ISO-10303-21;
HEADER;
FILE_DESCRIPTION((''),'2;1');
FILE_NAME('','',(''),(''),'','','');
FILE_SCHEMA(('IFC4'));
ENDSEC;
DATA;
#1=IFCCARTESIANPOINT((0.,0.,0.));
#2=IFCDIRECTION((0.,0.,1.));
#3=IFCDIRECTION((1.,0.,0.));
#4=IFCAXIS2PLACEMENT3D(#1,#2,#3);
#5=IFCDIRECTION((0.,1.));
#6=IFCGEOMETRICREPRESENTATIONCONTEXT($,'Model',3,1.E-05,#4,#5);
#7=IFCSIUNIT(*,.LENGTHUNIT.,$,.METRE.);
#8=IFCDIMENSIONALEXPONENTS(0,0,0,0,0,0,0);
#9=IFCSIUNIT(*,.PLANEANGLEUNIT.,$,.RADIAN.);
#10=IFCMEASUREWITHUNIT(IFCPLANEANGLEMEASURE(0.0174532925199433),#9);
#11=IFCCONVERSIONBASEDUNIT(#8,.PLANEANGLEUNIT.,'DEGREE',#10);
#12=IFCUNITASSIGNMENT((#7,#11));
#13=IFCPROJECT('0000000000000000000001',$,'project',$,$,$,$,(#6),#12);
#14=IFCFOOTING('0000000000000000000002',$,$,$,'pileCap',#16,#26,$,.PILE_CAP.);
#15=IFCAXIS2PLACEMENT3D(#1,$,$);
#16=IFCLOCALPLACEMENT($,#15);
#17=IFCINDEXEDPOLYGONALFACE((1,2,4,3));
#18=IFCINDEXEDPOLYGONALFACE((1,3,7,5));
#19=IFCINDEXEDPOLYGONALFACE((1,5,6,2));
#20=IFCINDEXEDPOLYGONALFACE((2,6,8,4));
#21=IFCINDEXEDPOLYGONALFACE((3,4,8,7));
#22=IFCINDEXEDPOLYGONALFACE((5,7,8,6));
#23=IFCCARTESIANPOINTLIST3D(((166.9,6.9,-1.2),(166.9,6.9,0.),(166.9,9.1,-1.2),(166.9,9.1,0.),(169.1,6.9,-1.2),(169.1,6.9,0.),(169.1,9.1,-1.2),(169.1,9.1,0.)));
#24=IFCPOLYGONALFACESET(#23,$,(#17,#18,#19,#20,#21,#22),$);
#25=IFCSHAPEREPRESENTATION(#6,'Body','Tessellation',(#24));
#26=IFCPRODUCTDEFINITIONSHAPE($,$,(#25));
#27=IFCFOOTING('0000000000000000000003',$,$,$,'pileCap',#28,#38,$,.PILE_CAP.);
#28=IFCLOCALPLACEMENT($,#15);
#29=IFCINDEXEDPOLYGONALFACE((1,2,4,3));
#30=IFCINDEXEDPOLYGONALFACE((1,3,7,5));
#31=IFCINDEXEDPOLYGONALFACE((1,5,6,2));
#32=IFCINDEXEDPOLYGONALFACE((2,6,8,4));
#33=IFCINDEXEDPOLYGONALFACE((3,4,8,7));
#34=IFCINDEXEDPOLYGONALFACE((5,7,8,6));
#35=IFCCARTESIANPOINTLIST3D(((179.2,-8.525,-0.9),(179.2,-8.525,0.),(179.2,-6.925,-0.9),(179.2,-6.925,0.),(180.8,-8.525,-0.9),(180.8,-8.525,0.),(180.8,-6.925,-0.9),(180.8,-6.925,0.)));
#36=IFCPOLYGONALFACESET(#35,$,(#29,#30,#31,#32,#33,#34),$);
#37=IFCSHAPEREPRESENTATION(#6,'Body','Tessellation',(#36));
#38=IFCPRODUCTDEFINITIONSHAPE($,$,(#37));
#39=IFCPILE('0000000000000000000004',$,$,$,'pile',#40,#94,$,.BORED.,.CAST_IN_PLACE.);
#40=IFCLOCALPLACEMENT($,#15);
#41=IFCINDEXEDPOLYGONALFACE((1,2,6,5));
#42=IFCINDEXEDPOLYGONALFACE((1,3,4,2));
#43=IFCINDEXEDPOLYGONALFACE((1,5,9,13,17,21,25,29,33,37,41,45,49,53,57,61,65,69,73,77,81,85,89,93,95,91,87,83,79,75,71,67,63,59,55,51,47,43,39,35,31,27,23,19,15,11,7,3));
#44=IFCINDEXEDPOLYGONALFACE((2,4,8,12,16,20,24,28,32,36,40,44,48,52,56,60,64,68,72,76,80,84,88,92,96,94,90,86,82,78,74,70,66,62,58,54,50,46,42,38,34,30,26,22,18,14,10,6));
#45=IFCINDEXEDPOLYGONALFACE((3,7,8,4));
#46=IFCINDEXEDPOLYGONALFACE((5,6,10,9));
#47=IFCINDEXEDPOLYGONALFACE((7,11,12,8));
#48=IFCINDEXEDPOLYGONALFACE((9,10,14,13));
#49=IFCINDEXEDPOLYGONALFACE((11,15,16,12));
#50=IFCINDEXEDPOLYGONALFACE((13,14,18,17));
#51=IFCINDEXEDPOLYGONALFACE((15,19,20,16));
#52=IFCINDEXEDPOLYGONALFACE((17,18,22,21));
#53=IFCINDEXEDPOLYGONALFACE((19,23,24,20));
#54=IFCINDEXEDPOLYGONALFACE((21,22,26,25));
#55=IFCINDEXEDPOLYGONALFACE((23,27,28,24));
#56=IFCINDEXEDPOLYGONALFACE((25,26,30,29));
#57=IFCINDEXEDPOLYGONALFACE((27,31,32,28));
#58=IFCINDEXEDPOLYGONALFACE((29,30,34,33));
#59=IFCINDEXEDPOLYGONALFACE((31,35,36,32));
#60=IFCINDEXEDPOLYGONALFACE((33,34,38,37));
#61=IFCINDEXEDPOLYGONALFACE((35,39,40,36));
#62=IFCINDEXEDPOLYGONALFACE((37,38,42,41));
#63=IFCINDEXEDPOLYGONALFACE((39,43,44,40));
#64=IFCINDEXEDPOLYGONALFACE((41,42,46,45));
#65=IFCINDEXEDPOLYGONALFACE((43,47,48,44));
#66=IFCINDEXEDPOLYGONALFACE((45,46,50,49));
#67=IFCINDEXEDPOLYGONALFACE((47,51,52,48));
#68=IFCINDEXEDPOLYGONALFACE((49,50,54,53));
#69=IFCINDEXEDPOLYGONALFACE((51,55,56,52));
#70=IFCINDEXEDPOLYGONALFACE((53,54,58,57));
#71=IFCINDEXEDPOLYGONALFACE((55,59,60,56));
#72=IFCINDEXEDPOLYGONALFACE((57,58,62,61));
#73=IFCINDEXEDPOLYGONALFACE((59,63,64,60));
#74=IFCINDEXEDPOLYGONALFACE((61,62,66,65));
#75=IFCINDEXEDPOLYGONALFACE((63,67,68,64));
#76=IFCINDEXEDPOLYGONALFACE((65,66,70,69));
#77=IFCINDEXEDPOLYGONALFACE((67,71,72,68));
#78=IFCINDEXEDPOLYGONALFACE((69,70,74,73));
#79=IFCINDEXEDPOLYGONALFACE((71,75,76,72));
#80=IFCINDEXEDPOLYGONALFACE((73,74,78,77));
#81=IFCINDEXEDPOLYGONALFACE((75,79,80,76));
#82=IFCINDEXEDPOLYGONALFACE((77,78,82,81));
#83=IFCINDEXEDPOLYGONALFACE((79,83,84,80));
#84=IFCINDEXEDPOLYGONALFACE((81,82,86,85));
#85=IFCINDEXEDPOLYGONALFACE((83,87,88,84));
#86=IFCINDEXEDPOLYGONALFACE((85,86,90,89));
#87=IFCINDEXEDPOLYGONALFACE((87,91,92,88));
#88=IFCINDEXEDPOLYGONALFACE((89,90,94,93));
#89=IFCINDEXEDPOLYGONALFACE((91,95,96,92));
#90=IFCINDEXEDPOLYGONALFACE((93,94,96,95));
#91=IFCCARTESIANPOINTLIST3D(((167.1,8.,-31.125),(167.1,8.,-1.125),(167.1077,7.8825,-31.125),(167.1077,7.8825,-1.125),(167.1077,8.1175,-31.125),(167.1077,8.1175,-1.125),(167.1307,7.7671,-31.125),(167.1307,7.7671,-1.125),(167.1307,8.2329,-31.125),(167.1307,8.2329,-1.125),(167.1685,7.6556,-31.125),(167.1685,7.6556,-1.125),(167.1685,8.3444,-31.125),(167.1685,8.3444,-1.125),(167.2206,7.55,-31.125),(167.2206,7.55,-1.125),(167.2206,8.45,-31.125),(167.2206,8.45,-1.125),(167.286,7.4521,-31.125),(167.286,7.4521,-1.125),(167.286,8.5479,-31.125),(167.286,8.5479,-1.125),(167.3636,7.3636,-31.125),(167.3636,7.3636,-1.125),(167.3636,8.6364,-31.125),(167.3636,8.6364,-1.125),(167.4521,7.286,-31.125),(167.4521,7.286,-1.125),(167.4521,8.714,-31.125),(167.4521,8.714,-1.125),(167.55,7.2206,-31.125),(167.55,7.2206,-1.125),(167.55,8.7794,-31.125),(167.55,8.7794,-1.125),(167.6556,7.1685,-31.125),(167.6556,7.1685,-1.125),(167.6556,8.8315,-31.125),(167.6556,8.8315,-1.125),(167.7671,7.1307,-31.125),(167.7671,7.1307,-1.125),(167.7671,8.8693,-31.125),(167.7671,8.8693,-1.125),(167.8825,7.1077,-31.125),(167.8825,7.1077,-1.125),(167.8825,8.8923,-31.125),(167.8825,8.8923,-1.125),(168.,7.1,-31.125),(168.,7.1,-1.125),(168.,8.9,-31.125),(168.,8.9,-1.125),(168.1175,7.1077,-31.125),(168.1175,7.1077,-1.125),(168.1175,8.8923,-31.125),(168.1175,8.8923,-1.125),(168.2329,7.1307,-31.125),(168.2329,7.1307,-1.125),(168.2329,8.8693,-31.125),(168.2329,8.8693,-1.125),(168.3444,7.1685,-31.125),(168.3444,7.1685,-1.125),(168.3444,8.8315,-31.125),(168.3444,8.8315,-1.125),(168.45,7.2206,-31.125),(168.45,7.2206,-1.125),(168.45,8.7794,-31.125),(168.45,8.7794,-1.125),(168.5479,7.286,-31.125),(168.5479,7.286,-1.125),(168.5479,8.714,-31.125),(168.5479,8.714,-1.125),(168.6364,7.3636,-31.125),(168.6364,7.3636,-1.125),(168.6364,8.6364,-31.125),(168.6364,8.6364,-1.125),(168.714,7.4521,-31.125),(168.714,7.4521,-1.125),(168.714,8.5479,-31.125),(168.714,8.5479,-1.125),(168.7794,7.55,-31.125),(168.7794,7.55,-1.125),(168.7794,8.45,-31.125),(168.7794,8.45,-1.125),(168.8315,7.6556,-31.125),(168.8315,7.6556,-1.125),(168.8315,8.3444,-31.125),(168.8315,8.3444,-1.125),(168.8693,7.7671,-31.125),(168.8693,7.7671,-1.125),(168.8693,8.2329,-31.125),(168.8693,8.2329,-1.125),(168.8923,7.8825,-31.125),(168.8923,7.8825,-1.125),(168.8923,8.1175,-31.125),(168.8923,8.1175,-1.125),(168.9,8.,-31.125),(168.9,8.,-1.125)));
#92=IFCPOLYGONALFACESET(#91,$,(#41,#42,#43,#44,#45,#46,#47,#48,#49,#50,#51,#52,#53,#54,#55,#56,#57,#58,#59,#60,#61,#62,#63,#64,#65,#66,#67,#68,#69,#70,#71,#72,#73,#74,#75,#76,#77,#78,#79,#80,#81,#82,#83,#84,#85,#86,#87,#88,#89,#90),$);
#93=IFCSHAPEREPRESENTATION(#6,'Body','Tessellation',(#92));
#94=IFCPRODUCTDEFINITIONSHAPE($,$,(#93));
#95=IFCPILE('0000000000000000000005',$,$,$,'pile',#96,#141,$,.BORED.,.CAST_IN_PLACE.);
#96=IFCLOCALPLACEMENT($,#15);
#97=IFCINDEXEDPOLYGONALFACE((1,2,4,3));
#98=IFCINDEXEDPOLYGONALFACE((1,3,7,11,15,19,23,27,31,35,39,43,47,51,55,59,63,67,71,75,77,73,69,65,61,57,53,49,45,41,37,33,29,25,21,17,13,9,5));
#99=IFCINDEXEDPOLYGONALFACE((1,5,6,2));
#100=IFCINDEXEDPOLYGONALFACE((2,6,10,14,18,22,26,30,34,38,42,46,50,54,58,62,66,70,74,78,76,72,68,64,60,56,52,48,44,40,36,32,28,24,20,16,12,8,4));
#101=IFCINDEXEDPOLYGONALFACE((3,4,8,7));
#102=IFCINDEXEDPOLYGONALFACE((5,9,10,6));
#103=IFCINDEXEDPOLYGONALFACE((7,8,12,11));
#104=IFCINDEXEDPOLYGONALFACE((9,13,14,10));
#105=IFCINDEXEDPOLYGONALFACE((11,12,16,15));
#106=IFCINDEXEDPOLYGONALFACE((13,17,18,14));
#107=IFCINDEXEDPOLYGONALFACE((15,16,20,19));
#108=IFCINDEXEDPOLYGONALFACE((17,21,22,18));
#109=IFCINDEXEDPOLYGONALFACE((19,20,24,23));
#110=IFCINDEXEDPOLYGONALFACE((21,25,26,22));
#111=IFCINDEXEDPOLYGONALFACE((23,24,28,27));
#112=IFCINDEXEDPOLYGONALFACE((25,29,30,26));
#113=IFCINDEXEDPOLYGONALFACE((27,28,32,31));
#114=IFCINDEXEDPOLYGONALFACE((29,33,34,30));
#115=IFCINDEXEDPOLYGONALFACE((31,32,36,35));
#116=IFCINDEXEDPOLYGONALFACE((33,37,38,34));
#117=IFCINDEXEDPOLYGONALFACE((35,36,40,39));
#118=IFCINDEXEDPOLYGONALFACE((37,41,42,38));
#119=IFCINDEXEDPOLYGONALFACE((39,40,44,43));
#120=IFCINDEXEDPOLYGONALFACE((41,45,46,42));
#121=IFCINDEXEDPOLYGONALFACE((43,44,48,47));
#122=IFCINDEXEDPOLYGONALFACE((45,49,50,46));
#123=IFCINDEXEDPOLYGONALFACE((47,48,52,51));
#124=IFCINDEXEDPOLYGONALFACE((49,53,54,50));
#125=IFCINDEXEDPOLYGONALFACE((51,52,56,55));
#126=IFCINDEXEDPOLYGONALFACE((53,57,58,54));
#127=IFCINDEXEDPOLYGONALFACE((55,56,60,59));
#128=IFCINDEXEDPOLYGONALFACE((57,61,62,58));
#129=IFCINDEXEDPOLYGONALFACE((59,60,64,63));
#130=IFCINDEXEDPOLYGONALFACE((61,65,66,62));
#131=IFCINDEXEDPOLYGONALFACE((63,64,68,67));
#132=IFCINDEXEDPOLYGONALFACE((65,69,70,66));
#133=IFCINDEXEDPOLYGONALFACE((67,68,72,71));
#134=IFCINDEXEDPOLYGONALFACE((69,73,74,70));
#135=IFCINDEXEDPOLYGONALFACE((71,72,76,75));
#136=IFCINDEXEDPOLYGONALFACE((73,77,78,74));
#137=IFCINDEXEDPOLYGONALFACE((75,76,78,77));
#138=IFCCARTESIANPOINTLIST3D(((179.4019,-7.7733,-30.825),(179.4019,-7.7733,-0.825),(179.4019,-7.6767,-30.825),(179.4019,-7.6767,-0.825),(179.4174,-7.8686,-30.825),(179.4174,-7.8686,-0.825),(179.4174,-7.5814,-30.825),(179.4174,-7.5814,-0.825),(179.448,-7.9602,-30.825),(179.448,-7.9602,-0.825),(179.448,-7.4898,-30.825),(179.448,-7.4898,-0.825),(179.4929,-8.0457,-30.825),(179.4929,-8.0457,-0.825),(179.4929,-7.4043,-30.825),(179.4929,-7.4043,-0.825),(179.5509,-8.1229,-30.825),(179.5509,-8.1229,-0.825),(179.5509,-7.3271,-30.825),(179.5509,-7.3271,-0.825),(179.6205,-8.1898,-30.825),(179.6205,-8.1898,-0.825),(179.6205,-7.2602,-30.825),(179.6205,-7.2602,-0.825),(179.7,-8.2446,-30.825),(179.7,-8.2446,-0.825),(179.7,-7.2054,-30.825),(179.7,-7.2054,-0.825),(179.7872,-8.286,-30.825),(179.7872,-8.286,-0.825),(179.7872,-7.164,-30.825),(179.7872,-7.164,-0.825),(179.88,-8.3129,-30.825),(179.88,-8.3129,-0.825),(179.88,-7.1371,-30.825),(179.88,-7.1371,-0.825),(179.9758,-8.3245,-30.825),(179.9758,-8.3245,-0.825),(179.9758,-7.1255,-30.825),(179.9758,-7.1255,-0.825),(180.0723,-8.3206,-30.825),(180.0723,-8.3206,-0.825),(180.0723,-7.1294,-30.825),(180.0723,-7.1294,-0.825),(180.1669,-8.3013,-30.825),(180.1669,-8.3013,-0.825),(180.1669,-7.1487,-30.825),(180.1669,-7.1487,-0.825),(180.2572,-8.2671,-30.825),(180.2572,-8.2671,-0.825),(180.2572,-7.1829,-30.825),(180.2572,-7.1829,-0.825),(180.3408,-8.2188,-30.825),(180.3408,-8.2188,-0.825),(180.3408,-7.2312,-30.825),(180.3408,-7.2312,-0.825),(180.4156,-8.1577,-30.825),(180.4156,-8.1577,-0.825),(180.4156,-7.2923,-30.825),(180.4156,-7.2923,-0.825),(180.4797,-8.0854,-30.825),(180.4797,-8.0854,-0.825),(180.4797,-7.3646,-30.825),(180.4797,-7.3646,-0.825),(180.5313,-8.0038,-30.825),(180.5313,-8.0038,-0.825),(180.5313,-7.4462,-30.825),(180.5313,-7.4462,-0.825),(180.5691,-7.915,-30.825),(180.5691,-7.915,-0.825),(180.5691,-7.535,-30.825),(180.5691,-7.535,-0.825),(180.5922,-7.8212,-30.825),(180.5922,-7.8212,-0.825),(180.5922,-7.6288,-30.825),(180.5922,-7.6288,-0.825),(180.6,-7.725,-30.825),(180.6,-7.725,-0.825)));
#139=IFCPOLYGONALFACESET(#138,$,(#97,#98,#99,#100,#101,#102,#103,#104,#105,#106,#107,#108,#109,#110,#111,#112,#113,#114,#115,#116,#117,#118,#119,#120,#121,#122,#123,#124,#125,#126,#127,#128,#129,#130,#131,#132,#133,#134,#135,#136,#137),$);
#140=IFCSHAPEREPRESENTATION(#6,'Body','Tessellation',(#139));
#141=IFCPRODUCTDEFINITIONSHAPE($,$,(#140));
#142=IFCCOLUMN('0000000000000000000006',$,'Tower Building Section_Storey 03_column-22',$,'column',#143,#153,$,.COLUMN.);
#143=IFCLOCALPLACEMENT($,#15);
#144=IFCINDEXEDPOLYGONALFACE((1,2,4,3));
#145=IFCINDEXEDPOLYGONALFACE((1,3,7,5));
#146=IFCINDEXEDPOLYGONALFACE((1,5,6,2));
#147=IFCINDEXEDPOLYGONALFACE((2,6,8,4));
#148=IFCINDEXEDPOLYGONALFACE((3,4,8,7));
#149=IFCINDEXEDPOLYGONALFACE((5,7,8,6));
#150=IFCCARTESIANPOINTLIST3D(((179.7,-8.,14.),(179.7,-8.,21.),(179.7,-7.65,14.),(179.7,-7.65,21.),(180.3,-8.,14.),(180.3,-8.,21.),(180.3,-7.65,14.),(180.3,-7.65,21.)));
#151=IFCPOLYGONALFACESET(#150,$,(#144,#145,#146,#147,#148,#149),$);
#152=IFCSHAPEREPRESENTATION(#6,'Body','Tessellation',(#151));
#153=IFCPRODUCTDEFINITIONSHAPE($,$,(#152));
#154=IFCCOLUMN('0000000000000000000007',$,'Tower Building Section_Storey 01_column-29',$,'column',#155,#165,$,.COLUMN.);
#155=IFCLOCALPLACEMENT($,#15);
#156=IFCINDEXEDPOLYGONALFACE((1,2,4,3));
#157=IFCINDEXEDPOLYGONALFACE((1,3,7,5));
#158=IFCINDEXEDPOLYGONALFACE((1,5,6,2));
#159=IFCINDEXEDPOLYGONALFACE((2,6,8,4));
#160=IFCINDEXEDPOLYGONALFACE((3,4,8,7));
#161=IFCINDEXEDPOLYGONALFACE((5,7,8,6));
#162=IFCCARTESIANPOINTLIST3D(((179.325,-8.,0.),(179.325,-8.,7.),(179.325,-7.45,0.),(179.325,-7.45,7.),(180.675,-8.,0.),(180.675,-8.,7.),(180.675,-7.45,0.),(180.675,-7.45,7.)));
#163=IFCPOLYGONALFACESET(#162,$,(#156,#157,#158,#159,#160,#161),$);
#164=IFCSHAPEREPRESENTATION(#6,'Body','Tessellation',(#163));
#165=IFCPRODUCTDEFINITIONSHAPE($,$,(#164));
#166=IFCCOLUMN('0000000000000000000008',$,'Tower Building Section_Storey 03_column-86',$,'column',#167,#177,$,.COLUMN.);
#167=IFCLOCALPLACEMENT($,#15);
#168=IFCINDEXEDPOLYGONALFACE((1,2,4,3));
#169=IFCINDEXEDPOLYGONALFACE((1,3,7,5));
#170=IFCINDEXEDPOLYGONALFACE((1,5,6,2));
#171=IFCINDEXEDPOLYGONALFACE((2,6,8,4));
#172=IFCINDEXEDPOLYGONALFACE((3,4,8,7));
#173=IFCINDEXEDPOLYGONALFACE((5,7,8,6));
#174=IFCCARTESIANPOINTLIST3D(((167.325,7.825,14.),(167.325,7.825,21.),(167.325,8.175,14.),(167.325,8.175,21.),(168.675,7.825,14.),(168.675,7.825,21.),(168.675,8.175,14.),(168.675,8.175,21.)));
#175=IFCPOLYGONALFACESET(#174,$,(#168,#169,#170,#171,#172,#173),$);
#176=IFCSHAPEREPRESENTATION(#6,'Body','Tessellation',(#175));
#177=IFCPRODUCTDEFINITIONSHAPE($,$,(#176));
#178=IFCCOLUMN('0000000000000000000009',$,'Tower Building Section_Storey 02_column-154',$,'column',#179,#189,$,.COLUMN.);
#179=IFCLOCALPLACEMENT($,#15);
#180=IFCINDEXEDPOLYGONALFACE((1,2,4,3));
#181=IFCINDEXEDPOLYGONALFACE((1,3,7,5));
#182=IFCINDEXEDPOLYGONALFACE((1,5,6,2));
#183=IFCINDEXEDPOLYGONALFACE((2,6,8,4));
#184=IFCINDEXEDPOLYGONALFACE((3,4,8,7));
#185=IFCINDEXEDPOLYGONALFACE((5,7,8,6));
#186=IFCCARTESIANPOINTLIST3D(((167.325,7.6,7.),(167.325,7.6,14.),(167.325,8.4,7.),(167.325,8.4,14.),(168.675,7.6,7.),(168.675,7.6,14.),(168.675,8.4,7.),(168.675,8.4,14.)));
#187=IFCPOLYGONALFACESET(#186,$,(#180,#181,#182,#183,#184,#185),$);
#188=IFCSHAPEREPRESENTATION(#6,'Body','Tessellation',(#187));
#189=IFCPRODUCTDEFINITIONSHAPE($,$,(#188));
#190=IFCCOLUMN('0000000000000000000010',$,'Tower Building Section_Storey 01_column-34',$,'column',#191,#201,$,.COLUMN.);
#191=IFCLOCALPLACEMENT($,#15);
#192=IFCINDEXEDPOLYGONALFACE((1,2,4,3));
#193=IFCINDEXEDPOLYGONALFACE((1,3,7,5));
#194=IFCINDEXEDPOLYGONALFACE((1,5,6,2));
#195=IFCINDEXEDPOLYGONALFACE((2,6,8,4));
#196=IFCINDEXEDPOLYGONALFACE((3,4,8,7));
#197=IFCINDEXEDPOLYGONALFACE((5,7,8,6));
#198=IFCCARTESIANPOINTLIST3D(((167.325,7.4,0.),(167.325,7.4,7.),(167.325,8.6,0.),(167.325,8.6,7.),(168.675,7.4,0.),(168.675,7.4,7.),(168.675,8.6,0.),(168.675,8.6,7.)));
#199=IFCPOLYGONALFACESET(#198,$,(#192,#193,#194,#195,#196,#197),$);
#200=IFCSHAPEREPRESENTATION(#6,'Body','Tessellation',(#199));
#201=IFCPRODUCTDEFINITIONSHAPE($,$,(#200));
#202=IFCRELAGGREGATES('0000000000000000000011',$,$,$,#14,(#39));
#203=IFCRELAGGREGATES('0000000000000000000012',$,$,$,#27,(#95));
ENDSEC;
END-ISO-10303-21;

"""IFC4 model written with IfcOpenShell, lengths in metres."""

from ifc_helpers import new_model, entity, si_unit, converted_unit, direction, frame, origin_with_axes, place, context, project, polyline, circle_curve, parameter, trimmed, segment, composite_curve, outline, extrude, element, aggregate, save


model = new_model("IFC4")

# Units and contexts
model_context = context("Model", 3, precision=1e-05, world=origin_with_axes(), true_north=direction((0.0, 1.0)))
ifc_project = project(units=[si_unit("LENGTHUNIT", "METRE"), converted_unit("PLANEANGLEUNIT", "DEGREE", entity("IfcPlaneAngleMeasure", 0.0174532925199433), si_unit("PLANEANGLEUNIT", "RADIAN"), dimensions=[0, 0, 0, 0, 0, 0, 0])], contexts=[model_context])

# Footings
placement_1 = place(None, origin_with_axes())
placement_2 = place(placement_1, origin_with_axes())
footing_1_placement = place(placement_2, frame((168.0, 8.0, -1.2), z_axis=(0.0, 0.0, 1.0), x_axis=(1.0, 0.0, 0.0)))
footing_1 = element("IfcFooting", 1, at=footing_1_placement, ObjectType="pileCap", PredefinedType="PILE_CAP", context=model_context, body=[
    extrude(outline(polyline([(1.1, -1.1, 0.0), (1.1, 1.1, 0.0), (-1.1, 1.1, 0.0), (-1.1, -1.1, 0.0), (1.1, -1.1, 0.0)])), origin_with_axes(), (0.0, 0.0, 1.0), 1.2),
])
footing_2_placement = place(placement_2, frame((180.0, -7.725, -0.9), z_axis=(0.0, 0.0, 1.0), x_axis=(1.0, 0.0, 0.0)))
footing_2 = element("IfcFooting", 2, at=footing_2_placement, ObjectType="pileCap", PredefinedType="PILE_CAP", context=model_context, body=[
    extrude(outline(polyline([(0.8, -0.8, 0.0), (0.8, 0.8, 0.0), (-0.8, 0.8, 0.0), (-0.8, -0.8, 0.0), (0.8, -0.8, 0.0)])), origin_with_axes(), (0.0, 0.0, 1.0), 0.9),
])

# Piles
pile_1_placement = place(footing_1_placement, frame((0.0, 0.0, -29.925), z_axis=(0.0, 0.0, 1.0), x_axis=(1.0, 0.0, 0.0)))
pile_1 = element("IfcPile", 3, at=pile_1_placement, ObjectType="pile", ConstructionType="CAST_IN_PLACE", PredefinedType="BORED", context=model_context, body=[
    extrude(outline(composite_curve([segment(trimmed(circle_curve(origin_with_axes(), 0.9), [parameter(0.0)], [parameter(360.0)], True, "PARAMETER"), True, "CONTINUOUS")], self_intersect=False)), origin_with_axes(), (0.0, 0.0, 1.0), 30.0),
])
aggregate(footing_1, [pile_1])
pile_2_placement = place(footing_2_placement, frame((0.0, 0.0, -29.925), z_axis=(0.0, 0.0, 1.0), x_axis=(1.0, 0.0, 0.0)))
pile_2 = element("IfcPile", 4, at=pile_2_placement, ObjectType="pile", ConstructionType="CAST_IN_PLACE", PredefinedType="BORED", context=model_context, body=[
    extrude(outline(composite_curve([segment(trimmed(circle_curve(origin_with_axes(), 0.6), [parameter(0.0)], [parameter(360.0)], True, "PARAMETER"), True, "CONTINUOUS")], self_intersect=False)), origin_with_axes(), (0.0, 0.0, 1.0), 30.0),
])
aggregate(footing_2, [pile_2])

# Columns
placement_3 = place(placement_1, frame((0.0, 0.0, 14.0), z_axis=(0.0, 0.0, 1.0), x_axis=(1.0, 0.0, 0.0)))
column_1_placement = place(placement_3, frame((180.0, -7.825, 0.0), z_axis=(0.0, 0.0, 1.0), x_axis=(1.0, 0.0, 0.0)))
element("IfcColumn", 5, at=column_1_placement, Name="Tower Building Section_Storey 03_column-22", ObjectType="column", PredefinedType="COLUMN", context=model_context, body=[
    extrude(outline(polyline([(-0.3, -0.175, 0.0), (0.3, -0.175, 0.0), (0.3, 0.175, 0.0), (-0.3, 0.175, 0.0), (-0.3, -0.175, 0.0)])), origin_with_axes(), (0.0, 0.0, 1.0), 7.0),
])
column_2_placement = place(placement_2, frame((180.0, -7.725, 0.0), z_axis=(0.0, 0.0, 1.0), x_axis=(1.0, 0.0, 0.0)))
element("IfcColumn", 6, at=column_2_placement, Name="Tower Building Section_Storey 01_column-29", ObjectType="column", PredefinedType="COLUMN", context=model_context, body=[
    extrude(outline(polyline([(-0.675, -0.275, 0.0), (0.675, -0.275, 0.0), (0.675, 0.275, 0.0), (-0.675, 0.275, 0.0), (-0.675, -0.275, 0.0)])), origin_with_axes(), (0.0, 0.0, 1.0), 7.0),
])
column_3_placement = place(placement_3, frame((168.0, 8.0, 0.0), z_axis=(0.0, 0.0, 1.0), x_axis=(1.0, 0.0, 0.0)))
element("IfcColumn", 7, at=column_3_placement, Name="Tower Building Section_Storey 03_column-86", ObjectType="column", PredefinedType="COLUMN", context=model_context, body=[
    extrude(outline(polyline([(-0.675, -0.175, 0.0), (0.675, -0.175, 0.0), (0.675, 0.175, 0.0), (-0.675, 0.175, 0.0), (-0.675, -0.175, 0.0)])), origin_with_axes(), (0.0, 0.0, 1.0), 7.0),
])
placement_4 = place(placement_1, frame((0.0, 0.0, 7.0), z_axis=(0.0, 0.0, 1.0), x_axis=(1.0, 0.0, 0.0)))
column_4_placement = place(placement_4, frame((168.0, 8.0, 0.0), z_axis=(0.0, 0.0, 1.0), x_axis=(1.0, 0.0, 0.0)))
element("IfcColumn", 8, at=column_4_placement, Name="Tower Building Section_Storey 02_column-154", ObjectType="column", PredefinedType="COLUMN", context=model_context, body=[
    extrude(outline(polyline([(-0.675, -0.4, 0.0), (0.675, -0.4, 0.0), (0.675, 0.4, 0.0), (-0.675, 0.4, 0.0), (-0.675, -0.4, 0.0)])), origin_with_axes(), (0.0, 0.0, 1.0), 7.0),
])
column_5_placement = place(placement_2, frame((168.0, 8.0, 0.0), z_axis=(0.0, 0.0, 1.0), x_axis=(1.0, 0.0, 0.0)))
element("IfcColumn", 9, at=column_5_placement, Name="Tower Building Section_Storey 01_column-34", ObjectType="column", PredefinedType="COLUMN", context=model_context, body=[
    extrude(outline(polyline([(-0.675, -0.6, 0.0), (0.675, -0.6, 0.0), (0.675, 0.6, 0.0), (-0.675, 0.6, 0.0), (-0.675, -0.6, 0.0)])), origin_with_axes(), (0.0, 0.0, 1.0), 7.0),
])

save(model, "model.ifc")
